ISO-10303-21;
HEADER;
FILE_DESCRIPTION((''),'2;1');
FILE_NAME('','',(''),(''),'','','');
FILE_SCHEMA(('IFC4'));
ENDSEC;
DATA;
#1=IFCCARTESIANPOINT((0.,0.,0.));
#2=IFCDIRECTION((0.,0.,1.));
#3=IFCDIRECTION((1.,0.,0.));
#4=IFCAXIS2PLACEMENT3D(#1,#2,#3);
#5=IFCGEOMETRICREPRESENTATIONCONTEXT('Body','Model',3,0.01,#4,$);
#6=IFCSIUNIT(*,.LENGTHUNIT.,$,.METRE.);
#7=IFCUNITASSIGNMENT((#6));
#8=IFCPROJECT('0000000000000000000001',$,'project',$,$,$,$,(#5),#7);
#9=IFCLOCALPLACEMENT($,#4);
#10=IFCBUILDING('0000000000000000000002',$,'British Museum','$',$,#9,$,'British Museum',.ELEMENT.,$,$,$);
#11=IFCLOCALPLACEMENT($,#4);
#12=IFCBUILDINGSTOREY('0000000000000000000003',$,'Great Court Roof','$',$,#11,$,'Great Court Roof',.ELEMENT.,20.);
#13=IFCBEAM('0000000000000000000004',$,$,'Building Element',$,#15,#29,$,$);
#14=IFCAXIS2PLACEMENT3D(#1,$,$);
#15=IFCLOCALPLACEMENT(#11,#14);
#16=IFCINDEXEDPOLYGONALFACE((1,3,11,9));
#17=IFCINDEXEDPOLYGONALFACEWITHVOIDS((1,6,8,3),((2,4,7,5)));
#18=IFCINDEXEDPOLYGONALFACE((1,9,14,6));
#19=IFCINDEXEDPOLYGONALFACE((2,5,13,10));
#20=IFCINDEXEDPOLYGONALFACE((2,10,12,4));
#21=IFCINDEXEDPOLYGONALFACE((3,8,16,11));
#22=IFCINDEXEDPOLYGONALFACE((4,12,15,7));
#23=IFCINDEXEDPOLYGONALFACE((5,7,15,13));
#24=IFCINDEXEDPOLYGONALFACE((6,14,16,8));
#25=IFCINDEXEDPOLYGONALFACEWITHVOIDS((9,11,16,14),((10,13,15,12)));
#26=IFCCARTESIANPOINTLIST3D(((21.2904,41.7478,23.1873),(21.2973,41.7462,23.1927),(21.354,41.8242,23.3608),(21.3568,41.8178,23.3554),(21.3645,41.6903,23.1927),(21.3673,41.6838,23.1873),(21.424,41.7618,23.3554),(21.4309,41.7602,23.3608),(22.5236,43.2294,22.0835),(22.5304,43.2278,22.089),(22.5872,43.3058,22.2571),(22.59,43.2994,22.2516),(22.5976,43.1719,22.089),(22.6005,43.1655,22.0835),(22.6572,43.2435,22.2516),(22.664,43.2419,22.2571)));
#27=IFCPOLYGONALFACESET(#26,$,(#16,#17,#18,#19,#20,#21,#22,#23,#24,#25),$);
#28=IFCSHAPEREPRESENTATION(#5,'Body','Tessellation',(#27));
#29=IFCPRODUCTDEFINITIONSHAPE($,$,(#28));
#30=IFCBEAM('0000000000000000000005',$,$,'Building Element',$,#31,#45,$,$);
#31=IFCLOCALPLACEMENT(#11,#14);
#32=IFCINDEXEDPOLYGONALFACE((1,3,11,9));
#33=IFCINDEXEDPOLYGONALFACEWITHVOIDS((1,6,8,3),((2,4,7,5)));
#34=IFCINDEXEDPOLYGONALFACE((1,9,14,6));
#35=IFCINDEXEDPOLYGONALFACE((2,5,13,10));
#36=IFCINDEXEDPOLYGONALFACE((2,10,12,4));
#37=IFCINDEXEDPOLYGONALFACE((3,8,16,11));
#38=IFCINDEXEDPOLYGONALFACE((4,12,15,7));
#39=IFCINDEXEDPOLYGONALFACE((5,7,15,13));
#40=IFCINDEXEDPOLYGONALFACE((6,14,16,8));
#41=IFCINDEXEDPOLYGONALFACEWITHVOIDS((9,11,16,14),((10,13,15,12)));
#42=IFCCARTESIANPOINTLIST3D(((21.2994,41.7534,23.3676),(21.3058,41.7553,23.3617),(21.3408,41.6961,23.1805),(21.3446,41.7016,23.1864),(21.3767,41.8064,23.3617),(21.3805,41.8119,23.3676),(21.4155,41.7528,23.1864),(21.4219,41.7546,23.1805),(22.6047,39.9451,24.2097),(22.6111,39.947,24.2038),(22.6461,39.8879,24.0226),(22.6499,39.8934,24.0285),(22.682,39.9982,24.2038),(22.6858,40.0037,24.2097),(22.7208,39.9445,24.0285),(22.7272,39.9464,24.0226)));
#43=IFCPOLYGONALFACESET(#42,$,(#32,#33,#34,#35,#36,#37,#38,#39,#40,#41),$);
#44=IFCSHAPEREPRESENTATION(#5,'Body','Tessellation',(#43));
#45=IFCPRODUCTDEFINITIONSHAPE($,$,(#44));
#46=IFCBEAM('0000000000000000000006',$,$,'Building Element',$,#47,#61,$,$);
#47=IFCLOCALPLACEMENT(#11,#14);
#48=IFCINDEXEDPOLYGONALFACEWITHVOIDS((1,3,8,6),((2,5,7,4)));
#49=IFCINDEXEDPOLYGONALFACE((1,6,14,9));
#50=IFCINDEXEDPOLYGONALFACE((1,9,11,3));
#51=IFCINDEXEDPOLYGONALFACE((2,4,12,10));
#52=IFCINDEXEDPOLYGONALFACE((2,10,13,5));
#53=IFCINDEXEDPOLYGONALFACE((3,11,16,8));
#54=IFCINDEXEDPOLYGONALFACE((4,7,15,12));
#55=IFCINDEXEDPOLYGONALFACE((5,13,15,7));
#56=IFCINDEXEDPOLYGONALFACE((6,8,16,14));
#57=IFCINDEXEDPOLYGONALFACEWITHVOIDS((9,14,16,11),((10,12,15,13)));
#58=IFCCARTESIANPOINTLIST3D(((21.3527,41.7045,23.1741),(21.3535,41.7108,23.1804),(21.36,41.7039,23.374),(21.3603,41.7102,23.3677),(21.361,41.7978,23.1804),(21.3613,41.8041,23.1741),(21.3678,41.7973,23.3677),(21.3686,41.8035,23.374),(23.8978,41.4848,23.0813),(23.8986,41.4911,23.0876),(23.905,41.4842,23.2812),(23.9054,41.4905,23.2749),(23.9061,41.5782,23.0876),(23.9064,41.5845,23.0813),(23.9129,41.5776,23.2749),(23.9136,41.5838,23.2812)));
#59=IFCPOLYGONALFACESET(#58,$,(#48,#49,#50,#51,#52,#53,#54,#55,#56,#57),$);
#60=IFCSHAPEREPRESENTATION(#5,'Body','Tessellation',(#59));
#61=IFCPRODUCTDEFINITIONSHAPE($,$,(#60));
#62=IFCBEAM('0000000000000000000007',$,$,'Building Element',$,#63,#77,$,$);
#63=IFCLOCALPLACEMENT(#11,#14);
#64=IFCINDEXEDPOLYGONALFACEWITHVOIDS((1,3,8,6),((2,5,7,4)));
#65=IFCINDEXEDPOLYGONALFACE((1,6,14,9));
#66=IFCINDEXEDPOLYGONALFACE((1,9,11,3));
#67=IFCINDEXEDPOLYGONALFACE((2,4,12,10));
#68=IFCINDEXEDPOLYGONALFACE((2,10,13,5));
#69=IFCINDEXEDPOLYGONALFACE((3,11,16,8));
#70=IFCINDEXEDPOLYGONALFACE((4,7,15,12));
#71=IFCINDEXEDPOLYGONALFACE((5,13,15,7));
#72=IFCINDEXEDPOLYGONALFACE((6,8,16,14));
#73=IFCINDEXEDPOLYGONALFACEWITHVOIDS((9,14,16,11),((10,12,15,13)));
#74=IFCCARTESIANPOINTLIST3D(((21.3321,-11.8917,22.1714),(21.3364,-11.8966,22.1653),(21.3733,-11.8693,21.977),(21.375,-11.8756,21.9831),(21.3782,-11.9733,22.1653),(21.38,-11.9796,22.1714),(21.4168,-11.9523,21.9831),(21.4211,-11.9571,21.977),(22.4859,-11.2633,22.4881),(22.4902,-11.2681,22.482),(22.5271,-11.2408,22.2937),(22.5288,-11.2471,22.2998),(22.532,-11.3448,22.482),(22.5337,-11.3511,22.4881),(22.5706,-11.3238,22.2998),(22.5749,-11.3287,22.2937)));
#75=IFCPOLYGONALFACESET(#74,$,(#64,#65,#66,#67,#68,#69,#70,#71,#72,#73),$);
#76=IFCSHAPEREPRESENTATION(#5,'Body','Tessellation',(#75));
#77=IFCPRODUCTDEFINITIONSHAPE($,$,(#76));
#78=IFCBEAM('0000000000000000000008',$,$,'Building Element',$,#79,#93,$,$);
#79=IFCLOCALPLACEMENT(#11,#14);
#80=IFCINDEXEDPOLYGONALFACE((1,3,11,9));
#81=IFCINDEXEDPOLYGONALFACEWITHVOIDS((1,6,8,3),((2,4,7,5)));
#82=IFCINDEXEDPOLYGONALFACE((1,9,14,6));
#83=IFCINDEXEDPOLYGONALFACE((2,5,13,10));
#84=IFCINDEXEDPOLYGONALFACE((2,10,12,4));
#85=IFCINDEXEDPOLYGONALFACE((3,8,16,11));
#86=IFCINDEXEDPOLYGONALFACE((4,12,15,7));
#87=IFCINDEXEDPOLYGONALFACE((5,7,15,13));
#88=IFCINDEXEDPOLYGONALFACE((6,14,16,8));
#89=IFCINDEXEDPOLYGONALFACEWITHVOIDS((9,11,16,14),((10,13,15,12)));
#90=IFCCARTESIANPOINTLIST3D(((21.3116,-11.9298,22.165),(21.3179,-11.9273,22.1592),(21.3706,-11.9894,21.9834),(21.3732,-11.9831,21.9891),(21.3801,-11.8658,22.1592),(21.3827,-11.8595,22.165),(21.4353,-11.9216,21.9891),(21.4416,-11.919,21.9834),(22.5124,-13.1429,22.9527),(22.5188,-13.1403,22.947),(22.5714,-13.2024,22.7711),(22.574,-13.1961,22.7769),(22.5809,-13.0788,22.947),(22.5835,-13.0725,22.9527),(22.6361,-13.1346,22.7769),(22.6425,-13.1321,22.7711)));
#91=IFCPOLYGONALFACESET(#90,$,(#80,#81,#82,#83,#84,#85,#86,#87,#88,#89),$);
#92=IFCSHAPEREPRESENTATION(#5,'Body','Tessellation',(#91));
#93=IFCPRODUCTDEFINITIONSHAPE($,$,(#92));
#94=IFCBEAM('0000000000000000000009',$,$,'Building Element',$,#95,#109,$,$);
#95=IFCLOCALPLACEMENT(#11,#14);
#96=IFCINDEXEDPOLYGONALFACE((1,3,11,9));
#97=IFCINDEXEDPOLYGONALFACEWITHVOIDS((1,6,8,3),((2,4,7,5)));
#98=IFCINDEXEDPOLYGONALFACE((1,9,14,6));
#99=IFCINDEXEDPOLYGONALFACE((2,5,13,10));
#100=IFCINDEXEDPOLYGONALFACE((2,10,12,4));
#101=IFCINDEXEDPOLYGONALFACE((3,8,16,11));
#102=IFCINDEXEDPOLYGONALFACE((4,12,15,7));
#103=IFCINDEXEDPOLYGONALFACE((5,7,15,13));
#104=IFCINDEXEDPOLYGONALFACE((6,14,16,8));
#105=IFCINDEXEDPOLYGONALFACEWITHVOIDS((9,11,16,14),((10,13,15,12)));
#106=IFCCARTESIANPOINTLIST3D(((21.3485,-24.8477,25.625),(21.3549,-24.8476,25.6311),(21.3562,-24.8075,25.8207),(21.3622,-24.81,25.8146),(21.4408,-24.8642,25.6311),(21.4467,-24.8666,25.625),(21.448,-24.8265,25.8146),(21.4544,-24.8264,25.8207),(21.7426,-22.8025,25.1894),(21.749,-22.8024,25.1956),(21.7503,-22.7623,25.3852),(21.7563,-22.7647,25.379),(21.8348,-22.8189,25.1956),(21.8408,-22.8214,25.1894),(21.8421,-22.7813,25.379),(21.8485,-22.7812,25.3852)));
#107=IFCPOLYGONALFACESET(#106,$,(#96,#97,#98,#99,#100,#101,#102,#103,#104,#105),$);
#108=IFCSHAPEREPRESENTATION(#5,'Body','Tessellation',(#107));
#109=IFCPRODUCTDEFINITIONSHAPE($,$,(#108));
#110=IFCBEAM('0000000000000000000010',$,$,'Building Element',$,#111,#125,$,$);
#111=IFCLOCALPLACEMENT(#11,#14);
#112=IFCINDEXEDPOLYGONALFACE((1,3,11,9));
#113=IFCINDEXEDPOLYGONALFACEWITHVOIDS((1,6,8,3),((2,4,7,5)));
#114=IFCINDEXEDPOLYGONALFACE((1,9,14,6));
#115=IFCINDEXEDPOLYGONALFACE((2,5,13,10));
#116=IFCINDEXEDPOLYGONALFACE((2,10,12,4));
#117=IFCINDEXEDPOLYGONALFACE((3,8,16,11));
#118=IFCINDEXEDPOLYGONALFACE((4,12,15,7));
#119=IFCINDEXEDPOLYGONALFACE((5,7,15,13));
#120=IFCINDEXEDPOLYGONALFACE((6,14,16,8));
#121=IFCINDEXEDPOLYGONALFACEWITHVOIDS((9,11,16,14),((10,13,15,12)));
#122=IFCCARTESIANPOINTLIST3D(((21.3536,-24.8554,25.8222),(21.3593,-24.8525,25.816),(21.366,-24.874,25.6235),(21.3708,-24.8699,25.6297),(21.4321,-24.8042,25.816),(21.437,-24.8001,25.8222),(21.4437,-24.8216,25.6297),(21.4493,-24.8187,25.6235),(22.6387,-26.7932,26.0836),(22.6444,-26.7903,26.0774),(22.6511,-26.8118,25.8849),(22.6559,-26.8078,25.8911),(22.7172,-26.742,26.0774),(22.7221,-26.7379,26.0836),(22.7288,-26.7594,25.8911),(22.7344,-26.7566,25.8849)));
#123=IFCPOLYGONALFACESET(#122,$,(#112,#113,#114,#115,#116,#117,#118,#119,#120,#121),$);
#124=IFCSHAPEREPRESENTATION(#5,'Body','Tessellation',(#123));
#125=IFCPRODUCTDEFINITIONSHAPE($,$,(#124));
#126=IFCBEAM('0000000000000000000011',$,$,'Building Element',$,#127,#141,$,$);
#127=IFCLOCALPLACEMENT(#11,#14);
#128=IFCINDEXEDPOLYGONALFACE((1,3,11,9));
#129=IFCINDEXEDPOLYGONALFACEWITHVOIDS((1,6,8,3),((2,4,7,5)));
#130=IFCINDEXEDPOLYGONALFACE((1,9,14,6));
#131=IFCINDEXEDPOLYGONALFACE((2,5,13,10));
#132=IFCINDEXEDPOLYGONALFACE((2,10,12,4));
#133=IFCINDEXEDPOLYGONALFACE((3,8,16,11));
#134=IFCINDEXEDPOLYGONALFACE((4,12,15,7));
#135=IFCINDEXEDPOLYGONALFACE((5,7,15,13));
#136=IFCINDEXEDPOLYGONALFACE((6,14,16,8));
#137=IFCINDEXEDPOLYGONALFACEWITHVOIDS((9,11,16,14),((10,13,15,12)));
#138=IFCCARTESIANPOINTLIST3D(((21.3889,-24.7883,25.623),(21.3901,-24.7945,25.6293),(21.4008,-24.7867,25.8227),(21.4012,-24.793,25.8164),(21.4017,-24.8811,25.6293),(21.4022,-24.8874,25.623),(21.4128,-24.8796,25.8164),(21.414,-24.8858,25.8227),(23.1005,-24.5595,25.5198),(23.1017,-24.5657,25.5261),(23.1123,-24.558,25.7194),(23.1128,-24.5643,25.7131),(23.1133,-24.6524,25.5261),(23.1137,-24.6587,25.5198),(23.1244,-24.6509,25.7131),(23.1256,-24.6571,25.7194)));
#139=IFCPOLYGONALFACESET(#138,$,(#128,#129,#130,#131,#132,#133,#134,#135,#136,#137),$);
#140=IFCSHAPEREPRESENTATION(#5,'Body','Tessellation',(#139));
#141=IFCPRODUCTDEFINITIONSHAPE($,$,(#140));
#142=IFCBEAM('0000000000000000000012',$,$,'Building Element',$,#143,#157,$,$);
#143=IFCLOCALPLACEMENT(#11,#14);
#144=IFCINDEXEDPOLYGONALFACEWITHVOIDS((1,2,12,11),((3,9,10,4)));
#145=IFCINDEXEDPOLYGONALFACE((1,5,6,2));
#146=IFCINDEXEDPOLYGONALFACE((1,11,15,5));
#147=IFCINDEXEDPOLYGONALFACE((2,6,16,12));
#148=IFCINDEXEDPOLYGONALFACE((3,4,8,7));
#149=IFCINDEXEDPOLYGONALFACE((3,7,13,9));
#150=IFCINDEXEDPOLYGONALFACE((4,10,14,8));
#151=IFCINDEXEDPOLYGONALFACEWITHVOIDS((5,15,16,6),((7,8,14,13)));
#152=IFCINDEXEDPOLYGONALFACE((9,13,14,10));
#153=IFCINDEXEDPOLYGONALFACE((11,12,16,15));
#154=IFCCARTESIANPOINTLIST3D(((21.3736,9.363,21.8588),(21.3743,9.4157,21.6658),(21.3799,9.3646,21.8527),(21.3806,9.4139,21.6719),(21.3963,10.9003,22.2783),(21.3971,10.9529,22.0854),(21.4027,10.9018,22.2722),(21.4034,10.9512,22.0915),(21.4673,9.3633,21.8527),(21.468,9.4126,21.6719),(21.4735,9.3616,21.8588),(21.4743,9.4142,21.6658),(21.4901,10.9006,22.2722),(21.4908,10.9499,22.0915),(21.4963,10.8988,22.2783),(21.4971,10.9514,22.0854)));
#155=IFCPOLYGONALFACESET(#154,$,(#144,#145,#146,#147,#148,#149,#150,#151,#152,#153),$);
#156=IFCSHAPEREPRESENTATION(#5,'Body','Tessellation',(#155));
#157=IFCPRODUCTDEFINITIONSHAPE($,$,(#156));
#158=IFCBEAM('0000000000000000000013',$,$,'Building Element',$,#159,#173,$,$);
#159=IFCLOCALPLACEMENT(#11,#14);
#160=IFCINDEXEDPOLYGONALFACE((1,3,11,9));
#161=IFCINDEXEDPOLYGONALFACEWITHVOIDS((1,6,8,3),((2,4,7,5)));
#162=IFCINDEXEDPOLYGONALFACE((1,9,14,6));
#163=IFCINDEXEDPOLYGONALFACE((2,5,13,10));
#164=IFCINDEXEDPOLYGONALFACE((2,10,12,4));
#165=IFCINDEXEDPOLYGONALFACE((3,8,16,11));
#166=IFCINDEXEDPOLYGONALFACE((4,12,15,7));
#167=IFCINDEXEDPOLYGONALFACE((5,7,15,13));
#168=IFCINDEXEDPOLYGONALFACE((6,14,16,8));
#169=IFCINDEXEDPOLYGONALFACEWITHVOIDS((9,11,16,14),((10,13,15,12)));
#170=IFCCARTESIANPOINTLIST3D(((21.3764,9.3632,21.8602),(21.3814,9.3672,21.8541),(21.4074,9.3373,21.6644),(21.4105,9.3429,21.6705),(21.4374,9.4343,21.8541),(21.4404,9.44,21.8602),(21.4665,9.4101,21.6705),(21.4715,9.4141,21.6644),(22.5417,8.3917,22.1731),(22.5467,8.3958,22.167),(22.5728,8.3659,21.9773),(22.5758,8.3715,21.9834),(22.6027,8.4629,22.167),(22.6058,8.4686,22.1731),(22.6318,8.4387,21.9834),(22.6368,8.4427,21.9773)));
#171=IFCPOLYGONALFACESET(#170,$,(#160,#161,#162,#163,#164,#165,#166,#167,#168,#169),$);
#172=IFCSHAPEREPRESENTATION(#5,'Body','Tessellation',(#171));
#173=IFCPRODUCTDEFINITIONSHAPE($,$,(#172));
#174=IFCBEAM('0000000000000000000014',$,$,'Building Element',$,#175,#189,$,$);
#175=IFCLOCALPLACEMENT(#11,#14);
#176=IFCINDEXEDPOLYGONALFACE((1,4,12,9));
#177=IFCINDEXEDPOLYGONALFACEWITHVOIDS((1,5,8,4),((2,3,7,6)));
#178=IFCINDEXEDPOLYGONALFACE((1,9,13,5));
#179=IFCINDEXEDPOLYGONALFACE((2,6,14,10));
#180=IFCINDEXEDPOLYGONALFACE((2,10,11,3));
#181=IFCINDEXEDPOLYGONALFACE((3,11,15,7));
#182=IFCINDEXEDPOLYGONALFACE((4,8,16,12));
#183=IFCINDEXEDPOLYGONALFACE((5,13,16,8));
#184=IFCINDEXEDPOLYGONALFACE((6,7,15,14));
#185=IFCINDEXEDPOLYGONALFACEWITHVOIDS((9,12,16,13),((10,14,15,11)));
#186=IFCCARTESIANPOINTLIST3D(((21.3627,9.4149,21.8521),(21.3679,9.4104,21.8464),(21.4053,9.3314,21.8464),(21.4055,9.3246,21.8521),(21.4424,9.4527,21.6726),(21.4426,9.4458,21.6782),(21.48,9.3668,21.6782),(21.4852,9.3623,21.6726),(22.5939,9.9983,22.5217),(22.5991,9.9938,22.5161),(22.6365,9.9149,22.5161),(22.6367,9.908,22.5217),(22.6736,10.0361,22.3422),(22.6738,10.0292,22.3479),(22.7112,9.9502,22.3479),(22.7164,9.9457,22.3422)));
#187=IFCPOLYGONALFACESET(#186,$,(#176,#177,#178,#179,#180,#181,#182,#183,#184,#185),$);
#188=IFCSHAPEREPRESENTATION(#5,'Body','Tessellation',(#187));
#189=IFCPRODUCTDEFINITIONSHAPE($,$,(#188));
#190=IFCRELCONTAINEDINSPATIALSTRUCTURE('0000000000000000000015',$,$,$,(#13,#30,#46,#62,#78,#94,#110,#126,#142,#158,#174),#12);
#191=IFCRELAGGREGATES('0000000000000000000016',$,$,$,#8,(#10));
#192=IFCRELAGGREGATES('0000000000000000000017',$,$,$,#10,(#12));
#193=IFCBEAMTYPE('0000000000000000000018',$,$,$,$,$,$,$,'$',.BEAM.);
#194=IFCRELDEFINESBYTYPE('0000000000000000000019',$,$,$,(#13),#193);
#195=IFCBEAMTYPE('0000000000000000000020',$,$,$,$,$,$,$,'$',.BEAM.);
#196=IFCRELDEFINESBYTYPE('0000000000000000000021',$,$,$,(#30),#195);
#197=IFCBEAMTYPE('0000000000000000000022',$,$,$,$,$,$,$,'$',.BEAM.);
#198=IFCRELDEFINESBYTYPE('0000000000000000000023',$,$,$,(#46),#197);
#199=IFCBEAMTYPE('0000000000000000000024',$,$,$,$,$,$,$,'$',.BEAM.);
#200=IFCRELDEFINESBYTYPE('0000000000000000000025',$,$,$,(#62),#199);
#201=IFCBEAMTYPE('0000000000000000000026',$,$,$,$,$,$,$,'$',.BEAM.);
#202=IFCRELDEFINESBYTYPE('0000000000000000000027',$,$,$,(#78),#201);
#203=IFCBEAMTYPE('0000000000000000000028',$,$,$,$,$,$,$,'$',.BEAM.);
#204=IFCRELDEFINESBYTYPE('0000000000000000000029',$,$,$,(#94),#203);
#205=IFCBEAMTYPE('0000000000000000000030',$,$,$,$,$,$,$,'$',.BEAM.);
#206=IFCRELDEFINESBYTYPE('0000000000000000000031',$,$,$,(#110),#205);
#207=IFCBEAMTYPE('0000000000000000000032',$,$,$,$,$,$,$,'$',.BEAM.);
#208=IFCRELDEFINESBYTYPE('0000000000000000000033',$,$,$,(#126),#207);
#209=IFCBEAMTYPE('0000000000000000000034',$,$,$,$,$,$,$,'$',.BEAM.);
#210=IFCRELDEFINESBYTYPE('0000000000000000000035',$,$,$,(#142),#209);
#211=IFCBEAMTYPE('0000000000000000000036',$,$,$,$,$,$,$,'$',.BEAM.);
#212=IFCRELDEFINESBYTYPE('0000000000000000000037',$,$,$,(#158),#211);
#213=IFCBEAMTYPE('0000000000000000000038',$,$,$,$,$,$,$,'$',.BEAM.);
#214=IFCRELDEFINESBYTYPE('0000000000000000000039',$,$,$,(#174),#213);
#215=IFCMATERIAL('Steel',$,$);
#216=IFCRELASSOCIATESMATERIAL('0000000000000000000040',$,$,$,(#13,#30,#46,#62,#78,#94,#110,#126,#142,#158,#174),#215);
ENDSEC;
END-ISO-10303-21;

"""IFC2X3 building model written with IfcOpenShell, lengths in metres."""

from ifc_helpers import new_model, si_unit, frame, origin_with_axes, origin_2d, place, context, project, spatial, hollow_rectangle, extrude, material, type_object, element, save


model = new_model("IFC2X3")

# Units and contexts
model_context = context("Model", 3, precision=0.01, world=origin_with_axes(), identifier="Body")
ifc_project = project(units=[si_unit("LENGTHUNIT", "METRE")], contexts=[model_context])

# Building, storey
building_placement = place(None, origin_with_axes())
building = spatial("IfcBuilding", under=ifc_project, at=building_placement, Name="British Museum", Description="$", LongName="British Museum", CompositionType="ELEMENT")
storey_placement = place(None, origin_with_axes())
storey = spatial("IfcBuildingStorey", under=building, at=storey_placement, Name="Great Court Roof", Description="$", LongName="Great Court Roof", CompositionType="ELEMENT", Elevation=20.0)

# Beams
ifc_material = material(Name="Steel")
beam_type_1 = type_object("IfcBeamType", ElementType="$", PredefinedType="BEAM")
beam_1_placement = place(None, origin_with_axes())
element("IfcBeam", 1, at=beam_1_placement, inside=storey, type_object=beam_type_1, material=ifc_material, Description="Building Element", context=model_context, shape_type="SweptSolid", body=[
    extrude(hollow_rectangle(XDim=0.1, YDim=0.2, WallThickness=0.0063, InnerFilletRadius=0.0, OuterFilletRadius=0.0, at=origin_2d()), frame((21.3606, 41.754, 23.2741), z_axis=(0.555151, 0.667007, -0.4969), x_axis=(-0.768611, 0.639716, 0.0)), (0.0, 0.0, 1.0), 2.2213),
])
beam_type_2 = type_object("IfcBeamType", ElementType="$", PredefinedType="BEAM")
beam_2_placement = place(None, origin_with_axes())
element("IfcBeam", 2, at=beam_2_placement, inside=storey, type_object=beam_type_2, material=ifc_material, Description="Building Element", context=model_context, shape_type="SweptSolid", body=[
    extrude(hollow_rectangle(XDim=0.1, YDim=0.2, WallThickness=0.0063, InnerFilletRadius=0.0, OuterFilletRadius=0.0, at=origin_2d()), frame((21.3606, 41.754, 23.2741), z_axis=(0.547566, -0.758546, 0.353242), x_axis=(0.810818, 0.585299, 0.0)), (0.0, 0.0, 1.0), 2.3838),
])
beam_type_3 = type_object("IfcBeamType", ElementType="$", PredefinedType="BEAM")
beam_3_placement = place(None, origin_with_axes())
element("IfcBeam", 3, at=beam_3_placement, inside=storey, type_object=beam_type_3, material=ifc_material, Description="Building Element", context=model_context, shape_type="SweptSolid", body=[
    extrude(hollow_rectangle(XDim=0.1, YDim=0.2, WallThickness=0.0063, InnerFilletRadius=0.0, OuterFilletRadius=0.0, at=origin_2d()), frame((21.3606, 41.754, 23.2741), z_axis=(0.995639, -0.085938, -0.036299), x_axis=(0.085995, 0.996296, 0.0)), (0.0, 0.0, 1.0), 2.5562),
])
beam_type_4 = type_object("IfcBeamType", ElementType="$", PredefinedType="BEAM")
beam_4_placement = place(None, origin_with_axes())
element("IfcBeam", 4, at=beam_4_placement, inside=storey, type_object=beam_type_4, material=ifc_material, Description="Building Element", context=model_context, shape_type="SweptSolid", body=[
    extrude(hollow_rectangle(XDim=0.1, YDim=0.2, WallThickness=0.0063, InnerFilletRadius=0.0, OuterFilletRadius=0.0, at=origin_2d()), frame((21.3766, -11.9244, 22.0742), z_axis=(0.853707, 0.465032, 0.234369), x_axis=(-0.478356, 0.878166, 0.0)), (0.0, 0.0, 1.0), 1.3515),
])
beam_type_5 = type_object("IfcBeamType", ElementType="$", PredefinedType="BEAM")
beam_5_placement = place(None, origin_with_axes())
element("IfcBeam", 5, at=beam_5_placement, inside=storey, type_object=beam_type_5, material=ifc_material, Description="Building Element", context=model_context, shape_type="SweptSolid", body=[
    extrude(hollow_rectangle(XDim=0.1, YDim=0.2, WallThickness=0.0063, InnerFilletRadius=0.0, OuterFilletRadius=0.0, at=origin_2d()), frame((21.3766, -11.9244, 22.0742), z_axis=(0.63877, -0.64527, 0.419046), x_axis=(0.710677, 0.703518, 0.0)), (0.0, 0.0, 1.0), 1.8799),
])
beam_type_6 = type_object("IfcBeamType", ElementType="$", PredefinedType="BEAM")
beam_6_placement = place(None, origin_with_axes())
element("IfcBeam", 6, at=beam_6_placement, inside=storey, type_object=beam_type_6, material=ifc_material, Description="Building Element", context=model_context, shape_type="SweptSolid", body=[
    extrude(hollow_rectangle(XDim=0.1, YDim=0.2, WallThickness=0.0063, InnerFilletRadius=0.0, OuterFilletRadius=0.0, at=origin_2d()), frame((21.4015, -24.8371, 25.7228), z_axis=(0.185189, 0.961148, -0.204696), x_axis=(-0.98194, 0.189195, 0.0)), (0.0, 0.0, 1.0), 2.1279),
])
beam_type_7 = type_object("IfcBeamType", ElementType="$", PredefinedType="BEAM")
beam_7_placement = place(None, origin_with_axes())
element("IfcBeam", 7, at=beam_7_placement, inside=storey, type_object=beam_type_7, material=ifc_material, Description="Building Element", context=model_context, shape_type="SweptSolid", body=[
    extrude(hollow_rectangle(XDim=0.1, YDim=0.2, WallThickness=0.0063, InnerFilletRadius=0.0, OuterFilletRadius=0.0, at=origin_2d()), frame((21.4015, -24.8371, 25.7228), z_axis=(0.549215, -0.828181, 0.111713), x_axis=(0.833397, 0.552674, 0.0)), (0.0, 0.0, 1.0), 2.3399),
])
beam_type_8 = type_object("IfcBeamType", ElementType="$", PredefinedType="BEAM")
beam_8_placement = place(None, origin_with_axes())
element("IfcBeam", 8, at=beam_8_placement, inside=storey, type_object=beam_type_8, material=ifc_material, Description="Building Element", context=model_context, shape_type="SweptSolid", body=[
    extrude(hollow_rectangle(XDim=0.1, YDim=0.2, WallThickness=0.0063, InnerFilletRadius=0.0, OuterFilletRadius=0.0, at=origin_2d()), frame((21.4015, -24.8371, 25.7228), z_axis=(0.98942, 0.13223, -0.059694), x_axis=(-0.132466, 0.991188, 0.0)), (0.0, 0.0, 1.0), 1.7299),
])
beam_type_9 = type_object("IfcBeamType", ElementType="$", PredefinedType="BEAM")
beam_9_placement = place(None, origin_with_axes())
element("IfcBeam", 9, at=beam_9_placement, inside=storey, type_object=beam_type_9, material=ifc_material, Description="Building Element", context=model_context, shape_type="SweptSolid", body=[
    extrude(hollow_rectangle(XDim=0.1, YDim=0.2, WallThickness=0.0063, InnerFilletRadius=0.0, OuterFilletRadius=0.0, at=origin_2d()), frame((21.4239, 9.3886, 21.7623), z_axis=(0.014306, 0.964618, 0.263263), x_axis=(-0.99989, 0.014829, 0.0)), (0.0, 0.0, 1.0), 1.5936),
])
beam_type_10 = type_object("IfcBeamType", ElementType="$", PredefinedType="BEAM")
beam_10_placement = place(None, origin_with_axes())
element("IfcBeam", 10, at=beam_10_placement, inside=storey, type_object=beam_type_10, material=ifc_material, Description="Building Element", context=model_context, shape_type="SweptSolid", body=[
    extrude(hollow_rectangle(XDim=0.1, YDim=0.2, WallThickness=0.0063, InnerFilletRadius=0.0, OuterFilletRadius=0.0, at=origin_2d()), frame((21.4239, 9.3886, 21.7623), z_axis=(0.752288, -0.627104, 0.201996), x_axis=(0.640303, 0.768122, 0.0)), (0.0, 0.0, 1.0), 1.549),
])
beam_type_11 = type_object("IfcBeamType", ElementType="$", PredefinedType="BEAM")
beam_11_placement = place(None, origin_with_axes())
element("IfcBeam", 11, at=beam_11_placement, inside=storey, type_object=beam_type_11, material=ifc_material, Description="Building Element", context=model_context, shape_type="SweptSolid", body=[
    extrude(hollow_rectangle(XDim=0.1, YDim=0.2, WallThickness=0.0063, InnerFilletRadius=0.0, OuterFilletRadius=0.0, at=origin_2d()), frame((21.4239, 9.3886, 21.7623), z_axis=(0.811007, 0.384293, 0.441119), x_axis=(-0.428206, 0.903681, 0.0)), (0.0, 0.0, 1.0), 1.5182),
])

save(model, "model.ifc")
